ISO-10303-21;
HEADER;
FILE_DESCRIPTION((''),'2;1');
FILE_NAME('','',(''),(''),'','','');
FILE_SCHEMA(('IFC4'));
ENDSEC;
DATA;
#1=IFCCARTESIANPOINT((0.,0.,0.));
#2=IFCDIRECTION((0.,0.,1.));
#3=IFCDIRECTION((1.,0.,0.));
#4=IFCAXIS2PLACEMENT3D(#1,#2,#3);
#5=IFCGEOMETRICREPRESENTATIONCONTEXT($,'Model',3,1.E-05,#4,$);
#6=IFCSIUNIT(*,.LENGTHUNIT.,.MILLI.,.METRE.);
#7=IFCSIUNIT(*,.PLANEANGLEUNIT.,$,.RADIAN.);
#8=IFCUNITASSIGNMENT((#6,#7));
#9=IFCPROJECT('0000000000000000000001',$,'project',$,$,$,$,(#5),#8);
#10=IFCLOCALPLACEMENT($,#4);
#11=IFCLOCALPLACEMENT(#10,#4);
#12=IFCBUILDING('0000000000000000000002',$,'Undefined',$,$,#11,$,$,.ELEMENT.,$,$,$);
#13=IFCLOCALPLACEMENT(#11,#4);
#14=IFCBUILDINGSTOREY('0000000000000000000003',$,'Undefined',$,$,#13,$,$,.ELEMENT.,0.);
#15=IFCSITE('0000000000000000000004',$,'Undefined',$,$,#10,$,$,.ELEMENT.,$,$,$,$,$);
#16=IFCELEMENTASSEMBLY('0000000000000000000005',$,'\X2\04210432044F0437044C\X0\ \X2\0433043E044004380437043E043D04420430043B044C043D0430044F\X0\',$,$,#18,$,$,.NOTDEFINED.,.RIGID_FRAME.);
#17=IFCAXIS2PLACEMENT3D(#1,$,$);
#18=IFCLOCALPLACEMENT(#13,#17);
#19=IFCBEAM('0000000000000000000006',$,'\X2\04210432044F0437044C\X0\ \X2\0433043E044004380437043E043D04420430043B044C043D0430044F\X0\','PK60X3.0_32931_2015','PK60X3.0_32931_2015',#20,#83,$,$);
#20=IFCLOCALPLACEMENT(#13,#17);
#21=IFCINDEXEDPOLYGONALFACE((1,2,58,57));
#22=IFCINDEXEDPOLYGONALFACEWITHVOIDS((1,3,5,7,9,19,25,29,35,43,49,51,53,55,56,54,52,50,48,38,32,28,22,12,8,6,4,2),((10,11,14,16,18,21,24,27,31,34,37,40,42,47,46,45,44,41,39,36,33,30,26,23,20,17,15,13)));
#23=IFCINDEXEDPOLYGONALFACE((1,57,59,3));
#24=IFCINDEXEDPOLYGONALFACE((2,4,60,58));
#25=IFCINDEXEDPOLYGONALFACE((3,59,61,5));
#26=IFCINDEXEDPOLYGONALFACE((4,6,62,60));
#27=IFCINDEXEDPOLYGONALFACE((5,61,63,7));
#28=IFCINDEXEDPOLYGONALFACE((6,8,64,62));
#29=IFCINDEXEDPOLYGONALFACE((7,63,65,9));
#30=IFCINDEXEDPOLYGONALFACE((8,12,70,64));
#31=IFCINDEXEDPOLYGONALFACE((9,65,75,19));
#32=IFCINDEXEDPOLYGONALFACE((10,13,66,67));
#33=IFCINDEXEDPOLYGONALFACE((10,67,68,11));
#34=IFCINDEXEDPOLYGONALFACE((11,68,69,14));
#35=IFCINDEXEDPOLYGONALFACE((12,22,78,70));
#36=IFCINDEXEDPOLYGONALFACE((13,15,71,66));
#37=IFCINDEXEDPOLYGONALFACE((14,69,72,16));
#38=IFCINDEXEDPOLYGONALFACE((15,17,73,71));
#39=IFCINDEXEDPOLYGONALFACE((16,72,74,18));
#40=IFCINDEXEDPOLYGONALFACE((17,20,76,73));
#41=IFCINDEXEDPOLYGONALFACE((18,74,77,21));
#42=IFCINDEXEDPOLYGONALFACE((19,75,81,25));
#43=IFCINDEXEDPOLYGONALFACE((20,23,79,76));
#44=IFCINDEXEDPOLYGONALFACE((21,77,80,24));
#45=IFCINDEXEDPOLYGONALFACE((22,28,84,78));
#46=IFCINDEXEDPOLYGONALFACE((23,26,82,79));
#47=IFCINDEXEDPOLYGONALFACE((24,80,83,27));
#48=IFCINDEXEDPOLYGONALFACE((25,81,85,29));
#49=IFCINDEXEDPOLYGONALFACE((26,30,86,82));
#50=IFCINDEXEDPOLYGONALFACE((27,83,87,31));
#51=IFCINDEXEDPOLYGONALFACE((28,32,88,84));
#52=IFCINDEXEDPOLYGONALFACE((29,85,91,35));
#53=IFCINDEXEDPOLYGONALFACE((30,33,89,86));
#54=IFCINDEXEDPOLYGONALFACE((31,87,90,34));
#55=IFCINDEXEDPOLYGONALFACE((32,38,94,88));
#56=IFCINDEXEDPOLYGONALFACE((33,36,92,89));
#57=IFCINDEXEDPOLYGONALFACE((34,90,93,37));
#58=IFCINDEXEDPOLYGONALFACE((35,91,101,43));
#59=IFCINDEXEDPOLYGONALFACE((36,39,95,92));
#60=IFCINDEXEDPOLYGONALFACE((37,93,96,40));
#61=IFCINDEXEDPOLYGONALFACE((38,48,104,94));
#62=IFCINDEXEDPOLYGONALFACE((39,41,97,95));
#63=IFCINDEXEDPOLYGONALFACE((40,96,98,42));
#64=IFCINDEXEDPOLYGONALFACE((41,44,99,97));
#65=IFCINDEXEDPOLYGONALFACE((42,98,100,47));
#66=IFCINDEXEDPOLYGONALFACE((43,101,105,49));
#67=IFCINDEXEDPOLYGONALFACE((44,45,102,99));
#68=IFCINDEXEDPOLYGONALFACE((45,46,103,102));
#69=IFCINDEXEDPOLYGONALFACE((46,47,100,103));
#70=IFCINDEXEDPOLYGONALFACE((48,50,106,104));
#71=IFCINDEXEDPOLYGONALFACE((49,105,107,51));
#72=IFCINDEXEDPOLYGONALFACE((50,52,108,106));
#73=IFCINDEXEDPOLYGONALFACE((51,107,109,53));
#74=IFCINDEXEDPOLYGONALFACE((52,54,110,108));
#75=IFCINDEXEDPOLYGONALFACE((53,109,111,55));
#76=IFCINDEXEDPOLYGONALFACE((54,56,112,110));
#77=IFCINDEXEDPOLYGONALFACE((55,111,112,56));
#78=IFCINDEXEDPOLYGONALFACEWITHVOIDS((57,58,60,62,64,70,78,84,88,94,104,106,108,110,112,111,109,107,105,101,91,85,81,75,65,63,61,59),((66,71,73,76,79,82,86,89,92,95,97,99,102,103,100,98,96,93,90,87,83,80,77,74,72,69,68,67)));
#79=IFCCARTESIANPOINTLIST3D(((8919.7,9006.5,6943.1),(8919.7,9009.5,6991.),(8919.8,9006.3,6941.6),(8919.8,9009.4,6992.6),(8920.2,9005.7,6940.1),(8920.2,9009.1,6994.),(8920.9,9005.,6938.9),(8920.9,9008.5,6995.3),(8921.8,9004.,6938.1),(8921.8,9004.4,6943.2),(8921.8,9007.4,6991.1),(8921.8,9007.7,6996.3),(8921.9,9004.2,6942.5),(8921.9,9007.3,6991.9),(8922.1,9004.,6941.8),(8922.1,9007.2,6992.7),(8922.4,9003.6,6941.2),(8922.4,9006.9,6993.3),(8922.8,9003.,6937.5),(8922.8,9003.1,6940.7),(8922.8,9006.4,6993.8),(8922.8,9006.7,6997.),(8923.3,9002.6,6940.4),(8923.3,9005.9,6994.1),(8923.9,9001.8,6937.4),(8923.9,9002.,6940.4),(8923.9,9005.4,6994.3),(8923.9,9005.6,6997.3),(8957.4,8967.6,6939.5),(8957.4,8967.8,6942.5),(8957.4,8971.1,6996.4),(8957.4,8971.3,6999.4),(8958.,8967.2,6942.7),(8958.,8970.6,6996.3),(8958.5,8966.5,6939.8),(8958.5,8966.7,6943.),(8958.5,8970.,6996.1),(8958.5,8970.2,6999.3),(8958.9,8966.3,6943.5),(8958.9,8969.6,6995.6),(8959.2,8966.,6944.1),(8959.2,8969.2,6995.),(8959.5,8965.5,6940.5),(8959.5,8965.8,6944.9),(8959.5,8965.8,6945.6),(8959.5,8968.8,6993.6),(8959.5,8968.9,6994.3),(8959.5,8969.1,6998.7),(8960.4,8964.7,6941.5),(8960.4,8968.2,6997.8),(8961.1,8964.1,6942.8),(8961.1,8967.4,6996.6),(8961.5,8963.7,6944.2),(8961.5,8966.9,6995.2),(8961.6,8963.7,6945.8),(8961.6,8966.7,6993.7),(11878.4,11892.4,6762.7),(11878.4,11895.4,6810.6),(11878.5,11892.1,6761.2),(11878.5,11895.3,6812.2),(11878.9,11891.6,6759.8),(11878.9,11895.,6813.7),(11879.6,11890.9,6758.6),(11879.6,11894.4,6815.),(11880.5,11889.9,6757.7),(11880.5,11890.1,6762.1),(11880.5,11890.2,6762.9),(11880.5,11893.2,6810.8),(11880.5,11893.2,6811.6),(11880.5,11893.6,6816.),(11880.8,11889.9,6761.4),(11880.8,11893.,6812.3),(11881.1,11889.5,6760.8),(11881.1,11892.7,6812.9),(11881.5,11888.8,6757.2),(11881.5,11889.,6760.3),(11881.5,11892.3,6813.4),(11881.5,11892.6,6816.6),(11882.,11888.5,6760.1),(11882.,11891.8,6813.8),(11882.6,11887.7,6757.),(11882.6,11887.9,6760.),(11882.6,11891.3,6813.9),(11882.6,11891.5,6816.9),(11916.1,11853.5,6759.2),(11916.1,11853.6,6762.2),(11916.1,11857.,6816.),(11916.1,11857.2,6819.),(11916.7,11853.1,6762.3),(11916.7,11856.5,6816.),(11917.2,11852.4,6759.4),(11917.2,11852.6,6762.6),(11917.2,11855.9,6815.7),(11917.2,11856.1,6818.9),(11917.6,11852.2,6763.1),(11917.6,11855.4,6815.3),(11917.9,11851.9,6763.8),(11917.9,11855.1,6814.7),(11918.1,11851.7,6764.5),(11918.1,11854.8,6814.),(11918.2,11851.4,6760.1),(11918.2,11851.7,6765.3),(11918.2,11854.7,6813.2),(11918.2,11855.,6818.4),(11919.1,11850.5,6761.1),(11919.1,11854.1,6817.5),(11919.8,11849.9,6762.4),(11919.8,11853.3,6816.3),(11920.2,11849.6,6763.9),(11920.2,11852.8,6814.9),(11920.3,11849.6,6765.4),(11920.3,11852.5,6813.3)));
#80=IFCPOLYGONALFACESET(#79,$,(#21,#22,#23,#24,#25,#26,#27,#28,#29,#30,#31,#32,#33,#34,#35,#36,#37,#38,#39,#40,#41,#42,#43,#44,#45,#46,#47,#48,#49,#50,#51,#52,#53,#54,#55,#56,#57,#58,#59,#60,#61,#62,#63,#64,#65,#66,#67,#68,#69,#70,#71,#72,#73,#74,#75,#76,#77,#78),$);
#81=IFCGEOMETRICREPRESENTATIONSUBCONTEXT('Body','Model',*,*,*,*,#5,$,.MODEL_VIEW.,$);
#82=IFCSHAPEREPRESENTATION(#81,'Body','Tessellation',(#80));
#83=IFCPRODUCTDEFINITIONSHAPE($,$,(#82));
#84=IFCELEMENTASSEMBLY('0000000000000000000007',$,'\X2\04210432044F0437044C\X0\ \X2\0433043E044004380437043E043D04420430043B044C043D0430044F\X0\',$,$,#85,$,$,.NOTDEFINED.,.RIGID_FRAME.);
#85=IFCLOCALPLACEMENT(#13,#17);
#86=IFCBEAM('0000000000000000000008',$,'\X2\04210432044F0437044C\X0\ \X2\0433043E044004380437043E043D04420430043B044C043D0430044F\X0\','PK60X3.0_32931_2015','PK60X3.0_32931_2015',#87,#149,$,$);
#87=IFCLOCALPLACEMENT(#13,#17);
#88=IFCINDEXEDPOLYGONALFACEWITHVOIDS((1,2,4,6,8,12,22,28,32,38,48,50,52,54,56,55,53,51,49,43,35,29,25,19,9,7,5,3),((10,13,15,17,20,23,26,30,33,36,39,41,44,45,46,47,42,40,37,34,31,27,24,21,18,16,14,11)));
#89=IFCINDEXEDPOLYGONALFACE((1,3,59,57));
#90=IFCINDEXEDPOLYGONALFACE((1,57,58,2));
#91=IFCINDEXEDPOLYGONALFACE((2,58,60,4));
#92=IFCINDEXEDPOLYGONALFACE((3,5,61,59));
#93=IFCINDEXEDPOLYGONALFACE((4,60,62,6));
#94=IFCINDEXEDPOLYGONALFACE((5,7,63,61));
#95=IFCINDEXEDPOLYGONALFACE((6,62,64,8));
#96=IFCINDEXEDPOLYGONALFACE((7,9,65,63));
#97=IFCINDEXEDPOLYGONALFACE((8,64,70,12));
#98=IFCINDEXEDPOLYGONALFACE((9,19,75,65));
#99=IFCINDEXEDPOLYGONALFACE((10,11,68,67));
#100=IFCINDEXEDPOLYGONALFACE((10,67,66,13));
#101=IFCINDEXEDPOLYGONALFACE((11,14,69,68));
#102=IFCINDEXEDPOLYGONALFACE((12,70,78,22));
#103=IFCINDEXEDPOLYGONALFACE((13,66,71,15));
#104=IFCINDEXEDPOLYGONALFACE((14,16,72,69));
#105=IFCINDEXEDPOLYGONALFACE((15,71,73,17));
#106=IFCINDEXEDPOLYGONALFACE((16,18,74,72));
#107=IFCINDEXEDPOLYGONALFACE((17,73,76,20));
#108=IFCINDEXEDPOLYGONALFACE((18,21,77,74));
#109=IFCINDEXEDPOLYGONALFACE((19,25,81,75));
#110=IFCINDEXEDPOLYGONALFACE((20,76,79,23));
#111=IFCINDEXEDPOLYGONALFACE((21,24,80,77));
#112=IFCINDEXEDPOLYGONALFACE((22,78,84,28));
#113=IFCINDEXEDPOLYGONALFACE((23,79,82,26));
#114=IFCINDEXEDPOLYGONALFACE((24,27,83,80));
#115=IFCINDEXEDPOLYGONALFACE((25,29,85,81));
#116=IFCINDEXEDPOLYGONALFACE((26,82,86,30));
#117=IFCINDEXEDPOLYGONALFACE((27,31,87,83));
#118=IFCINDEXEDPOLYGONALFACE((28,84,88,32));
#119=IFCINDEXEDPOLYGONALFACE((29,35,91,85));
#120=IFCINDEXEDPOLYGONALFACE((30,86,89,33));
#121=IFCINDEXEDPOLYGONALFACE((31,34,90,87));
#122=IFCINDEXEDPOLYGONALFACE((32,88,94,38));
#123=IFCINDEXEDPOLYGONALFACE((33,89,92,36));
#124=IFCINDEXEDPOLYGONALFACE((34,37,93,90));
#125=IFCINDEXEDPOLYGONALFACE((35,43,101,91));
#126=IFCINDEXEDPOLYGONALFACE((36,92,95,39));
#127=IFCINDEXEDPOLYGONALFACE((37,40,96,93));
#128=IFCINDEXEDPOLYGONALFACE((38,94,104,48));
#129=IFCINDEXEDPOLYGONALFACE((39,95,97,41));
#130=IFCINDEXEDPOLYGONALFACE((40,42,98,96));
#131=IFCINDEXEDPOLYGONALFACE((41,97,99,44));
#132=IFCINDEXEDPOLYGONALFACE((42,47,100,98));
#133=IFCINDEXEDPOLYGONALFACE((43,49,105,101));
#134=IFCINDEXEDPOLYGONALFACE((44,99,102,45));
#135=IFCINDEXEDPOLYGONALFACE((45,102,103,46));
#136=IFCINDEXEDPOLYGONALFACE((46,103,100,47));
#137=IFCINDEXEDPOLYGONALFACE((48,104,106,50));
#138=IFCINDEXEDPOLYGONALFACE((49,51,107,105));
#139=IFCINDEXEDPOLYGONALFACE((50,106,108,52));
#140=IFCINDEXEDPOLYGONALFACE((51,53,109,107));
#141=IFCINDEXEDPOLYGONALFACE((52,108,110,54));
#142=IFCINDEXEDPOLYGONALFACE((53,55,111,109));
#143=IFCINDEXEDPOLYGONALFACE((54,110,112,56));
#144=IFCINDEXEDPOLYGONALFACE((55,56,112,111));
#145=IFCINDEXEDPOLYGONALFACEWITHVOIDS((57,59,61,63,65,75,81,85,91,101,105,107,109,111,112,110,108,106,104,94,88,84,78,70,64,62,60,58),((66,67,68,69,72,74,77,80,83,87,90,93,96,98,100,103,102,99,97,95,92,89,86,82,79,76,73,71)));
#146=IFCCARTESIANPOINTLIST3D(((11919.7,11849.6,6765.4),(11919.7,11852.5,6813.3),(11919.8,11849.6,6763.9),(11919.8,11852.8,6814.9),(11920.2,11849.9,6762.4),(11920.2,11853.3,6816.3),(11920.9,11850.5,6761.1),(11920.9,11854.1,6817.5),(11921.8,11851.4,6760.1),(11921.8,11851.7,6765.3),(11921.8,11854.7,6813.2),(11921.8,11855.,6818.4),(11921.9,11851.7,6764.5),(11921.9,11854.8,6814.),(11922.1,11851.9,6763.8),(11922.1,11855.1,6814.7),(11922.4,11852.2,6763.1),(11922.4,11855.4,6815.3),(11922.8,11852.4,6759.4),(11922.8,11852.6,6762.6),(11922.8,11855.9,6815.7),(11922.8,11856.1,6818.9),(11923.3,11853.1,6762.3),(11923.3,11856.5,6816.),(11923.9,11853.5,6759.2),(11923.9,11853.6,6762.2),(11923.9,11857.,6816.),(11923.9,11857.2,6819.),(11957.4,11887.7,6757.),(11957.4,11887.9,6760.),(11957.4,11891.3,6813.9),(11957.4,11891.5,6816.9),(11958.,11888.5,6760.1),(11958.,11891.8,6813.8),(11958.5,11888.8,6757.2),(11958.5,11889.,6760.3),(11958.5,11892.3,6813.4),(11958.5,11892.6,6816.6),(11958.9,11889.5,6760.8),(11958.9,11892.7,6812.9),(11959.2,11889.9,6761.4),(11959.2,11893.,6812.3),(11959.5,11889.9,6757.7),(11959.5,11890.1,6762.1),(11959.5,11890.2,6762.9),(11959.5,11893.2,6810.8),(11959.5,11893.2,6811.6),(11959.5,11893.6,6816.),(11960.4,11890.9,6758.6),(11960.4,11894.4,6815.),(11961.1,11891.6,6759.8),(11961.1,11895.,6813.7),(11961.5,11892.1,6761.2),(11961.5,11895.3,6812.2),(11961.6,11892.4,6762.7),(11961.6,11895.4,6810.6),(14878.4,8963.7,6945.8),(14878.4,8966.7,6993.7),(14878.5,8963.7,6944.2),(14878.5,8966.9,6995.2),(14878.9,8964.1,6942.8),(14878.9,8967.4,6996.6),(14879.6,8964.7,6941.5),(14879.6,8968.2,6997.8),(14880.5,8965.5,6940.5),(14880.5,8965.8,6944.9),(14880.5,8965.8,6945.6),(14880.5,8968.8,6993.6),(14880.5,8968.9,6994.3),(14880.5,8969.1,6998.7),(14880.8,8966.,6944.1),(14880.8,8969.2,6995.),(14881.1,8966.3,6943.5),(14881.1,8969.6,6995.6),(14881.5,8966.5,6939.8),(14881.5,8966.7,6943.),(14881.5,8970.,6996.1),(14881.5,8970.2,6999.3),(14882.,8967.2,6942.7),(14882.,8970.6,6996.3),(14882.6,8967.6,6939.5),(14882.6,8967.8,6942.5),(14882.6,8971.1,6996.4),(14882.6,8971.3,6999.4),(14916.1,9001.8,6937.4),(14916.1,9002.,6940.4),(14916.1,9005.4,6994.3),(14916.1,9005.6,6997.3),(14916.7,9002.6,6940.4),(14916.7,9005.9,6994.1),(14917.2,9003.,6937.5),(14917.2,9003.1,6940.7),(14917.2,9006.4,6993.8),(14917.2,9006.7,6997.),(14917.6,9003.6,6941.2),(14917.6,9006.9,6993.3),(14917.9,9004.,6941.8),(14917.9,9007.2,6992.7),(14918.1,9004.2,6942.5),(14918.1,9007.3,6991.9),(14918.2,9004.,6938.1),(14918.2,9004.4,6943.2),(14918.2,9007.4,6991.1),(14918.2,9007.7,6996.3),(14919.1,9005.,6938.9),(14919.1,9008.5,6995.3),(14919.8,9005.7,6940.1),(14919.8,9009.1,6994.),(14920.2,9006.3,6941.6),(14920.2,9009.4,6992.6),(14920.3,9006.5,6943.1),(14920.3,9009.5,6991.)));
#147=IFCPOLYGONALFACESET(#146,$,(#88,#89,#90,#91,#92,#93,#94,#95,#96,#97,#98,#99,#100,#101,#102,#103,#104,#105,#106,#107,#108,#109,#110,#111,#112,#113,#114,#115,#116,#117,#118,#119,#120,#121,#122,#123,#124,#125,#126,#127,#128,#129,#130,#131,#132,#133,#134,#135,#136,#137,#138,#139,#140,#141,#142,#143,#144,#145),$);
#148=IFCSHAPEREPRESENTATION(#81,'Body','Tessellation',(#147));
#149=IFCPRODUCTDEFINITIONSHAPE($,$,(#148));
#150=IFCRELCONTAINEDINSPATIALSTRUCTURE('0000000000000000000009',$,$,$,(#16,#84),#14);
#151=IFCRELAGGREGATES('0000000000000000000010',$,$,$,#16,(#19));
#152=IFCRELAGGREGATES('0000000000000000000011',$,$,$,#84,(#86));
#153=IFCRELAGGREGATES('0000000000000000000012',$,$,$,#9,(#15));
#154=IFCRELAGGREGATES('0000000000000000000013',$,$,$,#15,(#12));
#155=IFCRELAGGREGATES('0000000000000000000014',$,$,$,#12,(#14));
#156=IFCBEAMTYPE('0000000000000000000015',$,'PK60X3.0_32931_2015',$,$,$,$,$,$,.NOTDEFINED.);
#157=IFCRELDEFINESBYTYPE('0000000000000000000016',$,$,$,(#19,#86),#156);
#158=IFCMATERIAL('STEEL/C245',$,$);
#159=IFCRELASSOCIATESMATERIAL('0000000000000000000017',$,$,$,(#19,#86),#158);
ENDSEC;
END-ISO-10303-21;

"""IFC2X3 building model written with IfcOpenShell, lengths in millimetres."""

from ifc_helpers import new_model, si_unit, frame, origin_with_axes, origin_2d_with_axis, place, context, subcontext, project, spatial, hollow_rectangle, extrude, material, type_object, element, aggregate, save


model = new_model("IFC2X3")

# Units and contexts
model_context = context("Model", 3, precision=1e-05, world=origin_with_axes())
body_context = subcontext(model_context, "Body", "Model", "MODEL_VIEW")
ifc_project = project(units=[si_unit("LENGTHUNIT", "METRE", prefix="MILLI"), si_unit("PLANEANGLEUNIT", "RADIAN")], contexts=[model_context])

# Site, building, storey
site_placement = place(None, origin_with_axes())
site = spatial("IfcSite", under=ifc_project, at=site_placement, Name="Undefined", CompositionType="ELEMENT")
building_placement = place(site_placement, origin_with_axes())
building = spatial("IfcBuilding", under=site, at=building_placement, Name="Undefined", CompositionType="ELEMENT")
storey_placement = place(building_placement, origin_with_axes())
storey = spatial("IfcBuildingStorey", under=building, at=storey_placement, Name="Undefined", CompositionType="ELEMENT", Elevation=0.0)

# Shared definitions
ifc_material = material(Name="STEEL/C245")

# Element assemblies, beams
assembly_1_placement = place(storey_placement, origin_with_axes())
assembly_1 = element("IfcElementAssembly", 1, at=assembly_1_placement, inside=storey, Name="Связь горизонтальная", AssemblyPlace="NOTDEFINED", PredefinedType="RIGID_FRAME")
beam_type_1 = type_object("IfcBeamType", Name="PK60X3.0_32931_2015", PredefinedType="NOTDEFINED")
beam_1_placement = place(assembly_1_placement, frame((11899.3, 11872.5, 6788.0), z_axis=(0.0, 0.062378, 0.998053), x_axis=(-0.715179, -0.69758, 0.043599)))
beam_1 = element("IfcBeam", 2, at=beam_1_placement, type_object=beam_type_1, material=ifc_material, Name="Связь горизонтальная", Description="PK60X3.0_32931_2015", ObjectType="PK60X3.0_32931_2015", context=body_context, shape_type="SweptSolid", body=[
    extrude(hollow_rectangle(XDim=60.0, YDim=60.0, WallThickness=3.0, InnerFilletRadius=3.0, OuterFilletRadius=6.0, at=origin_2d_with_axis()), frame((4137.0, 0.0, 0.0), z_axis=(-1.0, 0.0, 0.0), x_axis=(0.0, -1.0, 0.0)), (0.0, 0.0, 1.0), 4137.0),
])
aggregate(assembly_1, [beam_1])
assembly_2_placement = place(storey_placement, origin_with_axes())
assembly_2 = element("IfcElementAssembly", 3, at=assembly_2_placement, inside=storey, Name="Связь горизонтальная", AssemblyPlace="NOTDEFINED", PredefinedType="RIGID_FRAME")
beam_2_placement = place(assembly_2_placement, frame((11940.7, 11872.5, 6788.0), z_axis=(0.0, 0.062378, 0.998053), x_axis=(0.715179, -0.69758, 0.043599)))
beam_2 = element("IfcBeam", 4, at=beam_2_placement, type_object=beam_type_1, material=ifc_material, Name="Связь горизонтальная", Description="PK60X3.0_32931_2015", ObjectType="PK60X3.0_32931_2015", context=body_context, shape_type="SweptSolid", body=[
    extrude(hollow_rectangle(XDim=60.0, YDim=60.0, WallThickness=3.0, InnerFilletRadius=3.0, OuterFilletRadius=6.0, at=origin_2d_with_axis()), frame((4137.0, 0.0, 0.0), z_axis=(-1.0, 0.0, 0.0), x_axis=(0.0, -1.0, 0.0)), (0.0, 0.0, 1.0), 4137.0),
])
aggregate(assembly_2, [beam_2])

save(model, "model.ifc")
